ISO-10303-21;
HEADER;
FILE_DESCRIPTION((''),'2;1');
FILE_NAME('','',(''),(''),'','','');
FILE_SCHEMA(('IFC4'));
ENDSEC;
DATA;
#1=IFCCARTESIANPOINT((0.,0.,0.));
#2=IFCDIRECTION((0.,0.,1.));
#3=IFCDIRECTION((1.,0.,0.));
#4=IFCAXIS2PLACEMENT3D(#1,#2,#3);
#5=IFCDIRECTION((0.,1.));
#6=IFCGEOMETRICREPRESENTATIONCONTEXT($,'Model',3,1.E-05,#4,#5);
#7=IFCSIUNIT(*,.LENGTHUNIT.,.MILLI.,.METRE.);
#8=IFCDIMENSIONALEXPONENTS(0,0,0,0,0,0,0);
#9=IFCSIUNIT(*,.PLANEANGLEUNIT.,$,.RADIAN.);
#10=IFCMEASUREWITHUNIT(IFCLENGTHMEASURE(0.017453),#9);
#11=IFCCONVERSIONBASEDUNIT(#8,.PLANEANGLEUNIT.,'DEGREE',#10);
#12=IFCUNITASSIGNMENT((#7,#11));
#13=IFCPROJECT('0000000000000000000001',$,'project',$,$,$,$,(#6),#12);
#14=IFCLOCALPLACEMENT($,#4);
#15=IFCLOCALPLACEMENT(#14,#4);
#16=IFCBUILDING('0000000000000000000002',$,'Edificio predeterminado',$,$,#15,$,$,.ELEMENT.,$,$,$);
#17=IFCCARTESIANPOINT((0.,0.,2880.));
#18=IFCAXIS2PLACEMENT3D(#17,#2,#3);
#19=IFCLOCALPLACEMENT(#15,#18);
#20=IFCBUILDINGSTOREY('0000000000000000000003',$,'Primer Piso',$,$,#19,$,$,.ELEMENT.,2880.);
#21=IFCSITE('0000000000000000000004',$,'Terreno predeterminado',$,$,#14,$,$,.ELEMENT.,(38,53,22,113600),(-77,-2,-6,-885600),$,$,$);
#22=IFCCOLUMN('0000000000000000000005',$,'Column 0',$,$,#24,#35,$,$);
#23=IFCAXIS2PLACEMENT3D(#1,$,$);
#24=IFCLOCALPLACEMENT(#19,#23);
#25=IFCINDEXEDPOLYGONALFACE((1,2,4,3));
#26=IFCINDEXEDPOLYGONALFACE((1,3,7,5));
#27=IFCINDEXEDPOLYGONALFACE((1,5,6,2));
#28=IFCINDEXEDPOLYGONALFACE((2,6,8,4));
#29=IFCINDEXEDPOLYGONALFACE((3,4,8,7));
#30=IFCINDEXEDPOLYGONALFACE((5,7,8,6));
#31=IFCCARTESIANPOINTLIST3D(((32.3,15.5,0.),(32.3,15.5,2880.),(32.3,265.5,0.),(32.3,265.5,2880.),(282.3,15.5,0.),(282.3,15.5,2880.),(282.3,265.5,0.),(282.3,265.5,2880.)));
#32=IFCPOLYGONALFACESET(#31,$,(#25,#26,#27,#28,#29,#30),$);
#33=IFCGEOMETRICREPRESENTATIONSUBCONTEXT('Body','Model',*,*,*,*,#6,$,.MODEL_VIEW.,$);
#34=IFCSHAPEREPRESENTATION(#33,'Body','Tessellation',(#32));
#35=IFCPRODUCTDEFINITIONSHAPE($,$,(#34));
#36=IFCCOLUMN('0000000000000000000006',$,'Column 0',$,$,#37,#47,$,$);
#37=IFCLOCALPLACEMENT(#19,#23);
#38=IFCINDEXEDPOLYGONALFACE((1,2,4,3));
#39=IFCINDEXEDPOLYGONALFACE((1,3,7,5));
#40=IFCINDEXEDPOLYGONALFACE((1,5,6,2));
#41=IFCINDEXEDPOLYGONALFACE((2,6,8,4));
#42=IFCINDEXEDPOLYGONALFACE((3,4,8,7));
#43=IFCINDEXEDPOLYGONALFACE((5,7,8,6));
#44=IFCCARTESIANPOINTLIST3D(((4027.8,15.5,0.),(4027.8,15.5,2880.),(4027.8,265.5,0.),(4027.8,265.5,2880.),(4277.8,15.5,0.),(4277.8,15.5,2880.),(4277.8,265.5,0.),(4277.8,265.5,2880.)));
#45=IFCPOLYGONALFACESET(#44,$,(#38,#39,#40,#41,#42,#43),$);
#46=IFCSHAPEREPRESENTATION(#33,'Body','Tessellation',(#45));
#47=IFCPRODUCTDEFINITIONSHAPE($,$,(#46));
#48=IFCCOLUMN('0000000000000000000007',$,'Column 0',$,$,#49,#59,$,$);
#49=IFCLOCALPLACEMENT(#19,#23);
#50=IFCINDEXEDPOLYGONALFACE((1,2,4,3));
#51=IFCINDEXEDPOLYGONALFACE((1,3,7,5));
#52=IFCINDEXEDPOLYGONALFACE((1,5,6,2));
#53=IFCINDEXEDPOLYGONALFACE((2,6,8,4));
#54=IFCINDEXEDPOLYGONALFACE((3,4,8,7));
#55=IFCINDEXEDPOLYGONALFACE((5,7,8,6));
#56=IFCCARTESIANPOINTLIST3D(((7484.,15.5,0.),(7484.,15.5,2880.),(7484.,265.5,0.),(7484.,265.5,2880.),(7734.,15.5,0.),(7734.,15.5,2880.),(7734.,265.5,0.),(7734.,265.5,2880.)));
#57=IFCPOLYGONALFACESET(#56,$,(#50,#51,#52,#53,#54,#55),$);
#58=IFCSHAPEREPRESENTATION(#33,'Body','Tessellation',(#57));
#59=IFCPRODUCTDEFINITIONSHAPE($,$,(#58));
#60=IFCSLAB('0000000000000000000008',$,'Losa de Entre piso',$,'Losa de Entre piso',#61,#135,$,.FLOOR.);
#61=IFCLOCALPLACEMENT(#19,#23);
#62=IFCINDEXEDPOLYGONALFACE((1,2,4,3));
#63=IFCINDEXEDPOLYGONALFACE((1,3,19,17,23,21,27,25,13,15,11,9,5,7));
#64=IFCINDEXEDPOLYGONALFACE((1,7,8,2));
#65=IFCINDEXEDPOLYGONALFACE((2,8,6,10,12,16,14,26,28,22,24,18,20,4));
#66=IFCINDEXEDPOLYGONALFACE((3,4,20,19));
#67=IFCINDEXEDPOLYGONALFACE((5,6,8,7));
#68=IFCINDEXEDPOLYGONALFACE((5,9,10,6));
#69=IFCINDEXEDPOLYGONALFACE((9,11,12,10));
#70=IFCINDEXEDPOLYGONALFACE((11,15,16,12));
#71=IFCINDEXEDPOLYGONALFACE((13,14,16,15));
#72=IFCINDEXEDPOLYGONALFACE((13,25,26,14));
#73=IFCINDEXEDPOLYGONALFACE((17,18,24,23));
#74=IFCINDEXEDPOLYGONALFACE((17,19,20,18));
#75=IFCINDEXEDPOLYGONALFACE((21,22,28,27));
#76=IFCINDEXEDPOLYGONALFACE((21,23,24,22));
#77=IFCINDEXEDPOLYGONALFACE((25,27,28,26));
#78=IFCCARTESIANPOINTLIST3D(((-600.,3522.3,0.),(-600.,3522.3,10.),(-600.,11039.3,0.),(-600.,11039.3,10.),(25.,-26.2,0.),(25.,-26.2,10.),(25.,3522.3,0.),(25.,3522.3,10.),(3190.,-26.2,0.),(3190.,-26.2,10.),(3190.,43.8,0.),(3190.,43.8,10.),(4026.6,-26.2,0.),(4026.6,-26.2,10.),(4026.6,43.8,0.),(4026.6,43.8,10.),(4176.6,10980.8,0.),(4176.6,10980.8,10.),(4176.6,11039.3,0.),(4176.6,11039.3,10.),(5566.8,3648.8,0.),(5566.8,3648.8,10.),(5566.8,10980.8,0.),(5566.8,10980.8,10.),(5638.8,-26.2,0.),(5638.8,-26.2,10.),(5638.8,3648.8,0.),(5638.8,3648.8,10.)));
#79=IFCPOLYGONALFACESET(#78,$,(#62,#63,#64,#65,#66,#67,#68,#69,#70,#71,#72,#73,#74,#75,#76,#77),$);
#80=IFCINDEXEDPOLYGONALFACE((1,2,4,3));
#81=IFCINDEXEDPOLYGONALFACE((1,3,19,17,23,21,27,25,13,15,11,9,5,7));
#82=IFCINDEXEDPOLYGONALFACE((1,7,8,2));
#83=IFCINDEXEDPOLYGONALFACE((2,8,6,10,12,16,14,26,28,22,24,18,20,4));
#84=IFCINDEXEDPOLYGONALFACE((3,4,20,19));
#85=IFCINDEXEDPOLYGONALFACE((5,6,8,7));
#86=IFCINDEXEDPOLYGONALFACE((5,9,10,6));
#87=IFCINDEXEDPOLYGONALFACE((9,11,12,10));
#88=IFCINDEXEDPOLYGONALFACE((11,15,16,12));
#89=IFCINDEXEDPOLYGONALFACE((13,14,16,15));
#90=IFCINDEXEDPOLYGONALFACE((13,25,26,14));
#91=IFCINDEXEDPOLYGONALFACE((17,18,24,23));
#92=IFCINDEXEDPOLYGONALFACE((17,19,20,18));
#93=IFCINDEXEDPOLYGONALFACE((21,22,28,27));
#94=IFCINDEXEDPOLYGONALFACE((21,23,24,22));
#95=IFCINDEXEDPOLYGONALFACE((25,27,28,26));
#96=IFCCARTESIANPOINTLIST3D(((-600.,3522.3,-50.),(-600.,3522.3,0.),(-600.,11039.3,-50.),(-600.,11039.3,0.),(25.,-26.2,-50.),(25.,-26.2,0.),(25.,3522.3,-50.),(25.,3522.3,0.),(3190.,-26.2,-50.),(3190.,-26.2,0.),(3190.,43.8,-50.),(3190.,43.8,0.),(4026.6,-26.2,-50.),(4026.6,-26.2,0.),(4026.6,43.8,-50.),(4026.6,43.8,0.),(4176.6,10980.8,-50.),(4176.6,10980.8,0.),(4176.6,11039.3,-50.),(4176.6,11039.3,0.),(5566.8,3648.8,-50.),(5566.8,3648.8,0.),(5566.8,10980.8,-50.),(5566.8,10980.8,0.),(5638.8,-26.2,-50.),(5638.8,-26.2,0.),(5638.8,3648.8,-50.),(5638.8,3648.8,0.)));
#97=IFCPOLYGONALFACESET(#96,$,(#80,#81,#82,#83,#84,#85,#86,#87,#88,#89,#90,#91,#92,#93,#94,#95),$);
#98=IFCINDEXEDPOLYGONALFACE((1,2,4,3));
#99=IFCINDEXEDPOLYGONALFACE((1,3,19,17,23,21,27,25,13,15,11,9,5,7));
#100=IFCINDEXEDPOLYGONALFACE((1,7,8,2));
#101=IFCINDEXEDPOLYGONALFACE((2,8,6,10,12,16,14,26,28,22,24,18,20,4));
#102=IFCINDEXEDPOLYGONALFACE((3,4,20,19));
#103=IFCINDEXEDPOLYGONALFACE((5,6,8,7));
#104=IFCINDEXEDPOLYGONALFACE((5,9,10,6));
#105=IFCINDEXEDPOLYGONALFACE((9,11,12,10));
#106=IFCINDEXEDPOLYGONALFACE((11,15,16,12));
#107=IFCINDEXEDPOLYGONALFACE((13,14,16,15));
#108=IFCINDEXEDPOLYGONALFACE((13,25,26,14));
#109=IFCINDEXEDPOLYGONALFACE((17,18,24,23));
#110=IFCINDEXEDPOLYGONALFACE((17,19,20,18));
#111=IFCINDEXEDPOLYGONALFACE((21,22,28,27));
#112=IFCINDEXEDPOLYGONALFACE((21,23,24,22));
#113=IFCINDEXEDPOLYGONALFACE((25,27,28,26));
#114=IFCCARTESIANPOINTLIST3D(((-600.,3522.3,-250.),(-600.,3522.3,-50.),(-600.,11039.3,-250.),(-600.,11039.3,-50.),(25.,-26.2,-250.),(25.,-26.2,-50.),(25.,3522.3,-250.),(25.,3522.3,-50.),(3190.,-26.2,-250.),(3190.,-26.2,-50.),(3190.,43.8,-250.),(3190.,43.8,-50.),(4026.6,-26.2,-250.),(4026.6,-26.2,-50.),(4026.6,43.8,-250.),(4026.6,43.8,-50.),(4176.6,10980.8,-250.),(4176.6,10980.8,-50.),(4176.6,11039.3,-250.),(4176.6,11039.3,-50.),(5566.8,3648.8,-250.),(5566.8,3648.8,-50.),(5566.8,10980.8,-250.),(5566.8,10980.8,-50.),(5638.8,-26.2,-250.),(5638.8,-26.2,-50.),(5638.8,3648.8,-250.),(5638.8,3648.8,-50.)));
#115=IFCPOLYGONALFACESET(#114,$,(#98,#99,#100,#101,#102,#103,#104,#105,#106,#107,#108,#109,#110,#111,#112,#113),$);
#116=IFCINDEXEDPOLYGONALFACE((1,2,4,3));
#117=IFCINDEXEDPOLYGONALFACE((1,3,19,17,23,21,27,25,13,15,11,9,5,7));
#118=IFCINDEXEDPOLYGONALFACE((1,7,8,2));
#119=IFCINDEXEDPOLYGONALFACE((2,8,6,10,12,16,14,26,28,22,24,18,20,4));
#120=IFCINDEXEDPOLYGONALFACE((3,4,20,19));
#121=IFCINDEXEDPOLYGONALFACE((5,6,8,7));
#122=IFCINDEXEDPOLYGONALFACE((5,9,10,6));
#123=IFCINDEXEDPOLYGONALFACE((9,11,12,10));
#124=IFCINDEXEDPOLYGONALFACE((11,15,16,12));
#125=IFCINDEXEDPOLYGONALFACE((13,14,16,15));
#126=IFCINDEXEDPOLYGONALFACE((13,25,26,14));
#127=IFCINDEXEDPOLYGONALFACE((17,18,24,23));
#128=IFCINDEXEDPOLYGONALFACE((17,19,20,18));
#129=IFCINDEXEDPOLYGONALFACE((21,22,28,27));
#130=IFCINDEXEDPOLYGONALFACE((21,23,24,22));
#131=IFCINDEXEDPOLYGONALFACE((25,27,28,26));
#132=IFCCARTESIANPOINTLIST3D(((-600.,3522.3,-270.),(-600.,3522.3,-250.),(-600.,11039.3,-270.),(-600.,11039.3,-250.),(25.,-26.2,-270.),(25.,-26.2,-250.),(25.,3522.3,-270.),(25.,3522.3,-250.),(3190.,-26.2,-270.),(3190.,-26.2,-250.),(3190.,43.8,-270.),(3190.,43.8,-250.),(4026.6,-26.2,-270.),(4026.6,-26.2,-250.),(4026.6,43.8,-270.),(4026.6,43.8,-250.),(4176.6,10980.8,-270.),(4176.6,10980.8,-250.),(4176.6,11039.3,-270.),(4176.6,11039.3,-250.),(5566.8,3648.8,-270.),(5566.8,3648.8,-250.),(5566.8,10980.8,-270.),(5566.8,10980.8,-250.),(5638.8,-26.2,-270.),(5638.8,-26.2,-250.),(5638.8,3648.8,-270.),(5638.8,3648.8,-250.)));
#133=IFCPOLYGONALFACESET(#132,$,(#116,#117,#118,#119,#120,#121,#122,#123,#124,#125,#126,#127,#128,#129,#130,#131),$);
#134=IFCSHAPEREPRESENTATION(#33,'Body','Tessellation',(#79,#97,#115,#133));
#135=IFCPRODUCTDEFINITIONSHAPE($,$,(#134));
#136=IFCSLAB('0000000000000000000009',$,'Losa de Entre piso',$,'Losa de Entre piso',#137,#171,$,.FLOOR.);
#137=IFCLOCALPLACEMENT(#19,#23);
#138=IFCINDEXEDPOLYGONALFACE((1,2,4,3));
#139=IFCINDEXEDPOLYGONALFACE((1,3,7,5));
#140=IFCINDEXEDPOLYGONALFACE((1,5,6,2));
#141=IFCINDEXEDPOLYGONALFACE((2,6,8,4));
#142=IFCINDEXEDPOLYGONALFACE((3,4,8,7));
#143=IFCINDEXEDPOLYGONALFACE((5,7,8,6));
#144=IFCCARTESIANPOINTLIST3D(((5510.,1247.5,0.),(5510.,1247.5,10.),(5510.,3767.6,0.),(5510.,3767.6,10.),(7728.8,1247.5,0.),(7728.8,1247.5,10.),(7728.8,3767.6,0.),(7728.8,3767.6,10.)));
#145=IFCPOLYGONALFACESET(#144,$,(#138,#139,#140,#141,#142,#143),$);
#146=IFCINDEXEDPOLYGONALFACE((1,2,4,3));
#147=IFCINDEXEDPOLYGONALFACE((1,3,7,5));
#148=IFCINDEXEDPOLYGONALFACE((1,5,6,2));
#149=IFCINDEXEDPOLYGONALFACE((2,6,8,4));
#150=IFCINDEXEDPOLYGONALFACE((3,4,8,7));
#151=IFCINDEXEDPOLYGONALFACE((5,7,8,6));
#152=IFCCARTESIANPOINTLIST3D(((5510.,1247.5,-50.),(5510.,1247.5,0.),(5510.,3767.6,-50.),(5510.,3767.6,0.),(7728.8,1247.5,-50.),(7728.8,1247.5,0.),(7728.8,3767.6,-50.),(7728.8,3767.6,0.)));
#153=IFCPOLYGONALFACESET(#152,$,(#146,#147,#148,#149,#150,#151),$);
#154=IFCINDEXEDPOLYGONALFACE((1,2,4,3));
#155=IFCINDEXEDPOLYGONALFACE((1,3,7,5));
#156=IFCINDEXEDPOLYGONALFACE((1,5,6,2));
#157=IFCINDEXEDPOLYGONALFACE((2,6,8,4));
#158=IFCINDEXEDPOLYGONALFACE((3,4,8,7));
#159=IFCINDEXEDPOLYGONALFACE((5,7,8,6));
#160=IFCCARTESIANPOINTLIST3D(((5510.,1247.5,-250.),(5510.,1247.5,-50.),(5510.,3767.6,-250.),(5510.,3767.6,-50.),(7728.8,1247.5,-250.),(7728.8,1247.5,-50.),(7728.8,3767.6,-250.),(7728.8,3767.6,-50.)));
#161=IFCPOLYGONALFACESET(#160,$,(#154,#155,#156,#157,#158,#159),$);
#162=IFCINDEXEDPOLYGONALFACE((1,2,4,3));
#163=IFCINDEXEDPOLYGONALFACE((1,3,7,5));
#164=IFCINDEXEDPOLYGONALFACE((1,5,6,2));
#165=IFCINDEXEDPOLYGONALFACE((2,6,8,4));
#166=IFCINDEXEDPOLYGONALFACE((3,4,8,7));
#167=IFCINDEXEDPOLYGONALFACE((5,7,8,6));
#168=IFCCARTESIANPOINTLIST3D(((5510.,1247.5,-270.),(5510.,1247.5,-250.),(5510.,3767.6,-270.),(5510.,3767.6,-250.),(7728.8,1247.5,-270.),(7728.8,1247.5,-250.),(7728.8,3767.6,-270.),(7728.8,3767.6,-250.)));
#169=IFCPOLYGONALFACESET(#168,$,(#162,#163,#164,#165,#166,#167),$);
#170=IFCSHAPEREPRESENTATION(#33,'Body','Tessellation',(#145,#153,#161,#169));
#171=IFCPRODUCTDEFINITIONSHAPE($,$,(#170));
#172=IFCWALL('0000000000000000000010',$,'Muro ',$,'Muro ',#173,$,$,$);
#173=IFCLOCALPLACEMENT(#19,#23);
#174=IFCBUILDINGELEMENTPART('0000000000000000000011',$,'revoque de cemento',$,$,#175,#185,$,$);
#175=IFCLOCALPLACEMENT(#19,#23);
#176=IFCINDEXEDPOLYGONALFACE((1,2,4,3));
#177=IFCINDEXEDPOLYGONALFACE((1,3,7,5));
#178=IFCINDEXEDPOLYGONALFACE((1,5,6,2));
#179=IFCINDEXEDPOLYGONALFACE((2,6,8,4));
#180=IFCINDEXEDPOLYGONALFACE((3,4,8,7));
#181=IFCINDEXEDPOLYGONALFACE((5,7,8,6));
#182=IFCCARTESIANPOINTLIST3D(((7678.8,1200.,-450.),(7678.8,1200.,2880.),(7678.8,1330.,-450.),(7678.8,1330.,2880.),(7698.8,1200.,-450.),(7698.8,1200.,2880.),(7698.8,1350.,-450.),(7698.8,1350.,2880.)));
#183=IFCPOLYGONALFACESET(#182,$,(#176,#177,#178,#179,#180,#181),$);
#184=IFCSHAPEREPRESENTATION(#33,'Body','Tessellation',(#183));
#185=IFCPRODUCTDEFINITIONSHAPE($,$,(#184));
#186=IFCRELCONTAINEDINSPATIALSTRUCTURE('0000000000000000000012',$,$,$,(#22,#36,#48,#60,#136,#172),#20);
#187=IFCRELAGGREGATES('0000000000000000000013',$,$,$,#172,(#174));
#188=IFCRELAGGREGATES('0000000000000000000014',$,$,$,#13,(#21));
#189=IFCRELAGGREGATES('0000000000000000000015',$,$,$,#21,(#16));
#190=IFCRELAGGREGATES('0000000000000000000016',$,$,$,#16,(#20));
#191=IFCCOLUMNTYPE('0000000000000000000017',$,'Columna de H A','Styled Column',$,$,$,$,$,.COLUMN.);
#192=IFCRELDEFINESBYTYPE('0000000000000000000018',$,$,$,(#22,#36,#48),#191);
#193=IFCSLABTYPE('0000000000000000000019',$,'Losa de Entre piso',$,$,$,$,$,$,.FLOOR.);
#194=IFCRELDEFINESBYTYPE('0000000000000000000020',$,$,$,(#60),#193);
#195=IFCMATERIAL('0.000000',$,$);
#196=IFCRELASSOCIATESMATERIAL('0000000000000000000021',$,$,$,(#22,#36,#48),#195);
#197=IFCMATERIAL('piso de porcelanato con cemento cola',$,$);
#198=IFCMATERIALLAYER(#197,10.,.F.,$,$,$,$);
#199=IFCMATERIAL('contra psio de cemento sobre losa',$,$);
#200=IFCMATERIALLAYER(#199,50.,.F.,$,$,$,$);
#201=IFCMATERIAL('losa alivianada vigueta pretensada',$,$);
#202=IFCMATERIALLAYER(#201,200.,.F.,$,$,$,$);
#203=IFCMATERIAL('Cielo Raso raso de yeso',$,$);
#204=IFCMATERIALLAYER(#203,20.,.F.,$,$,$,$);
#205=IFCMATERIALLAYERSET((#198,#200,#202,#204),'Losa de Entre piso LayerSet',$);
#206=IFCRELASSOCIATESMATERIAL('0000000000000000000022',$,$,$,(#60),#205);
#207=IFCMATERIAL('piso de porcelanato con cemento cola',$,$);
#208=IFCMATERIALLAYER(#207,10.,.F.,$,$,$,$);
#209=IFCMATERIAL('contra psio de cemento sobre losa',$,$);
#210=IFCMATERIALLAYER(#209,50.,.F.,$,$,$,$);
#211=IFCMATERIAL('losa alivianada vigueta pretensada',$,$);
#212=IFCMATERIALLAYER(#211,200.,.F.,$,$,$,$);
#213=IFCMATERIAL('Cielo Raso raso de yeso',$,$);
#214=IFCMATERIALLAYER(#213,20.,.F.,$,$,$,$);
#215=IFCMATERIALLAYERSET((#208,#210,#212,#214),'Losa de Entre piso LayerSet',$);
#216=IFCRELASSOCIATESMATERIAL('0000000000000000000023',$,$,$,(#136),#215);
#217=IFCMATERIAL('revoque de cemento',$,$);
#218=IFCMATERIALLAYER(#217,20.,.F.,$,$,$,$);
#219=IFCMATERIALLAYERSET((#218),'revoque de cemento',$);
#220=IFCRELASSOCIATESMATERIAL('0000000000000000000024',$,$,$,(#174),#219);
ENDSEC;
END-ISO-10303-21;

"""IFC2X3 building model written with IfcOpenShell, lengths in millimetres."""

from ifc_helpers import new_model, entity, si_unit, converted_unit, direction, frame, origin_with_axes, place, context, subcontext, project, spatial, polyline, outline, extrude, clip, bounded_halfspace, material, layer, layer_set, layer_usage, type_object, element, aggregate, save


model = new_model("IFC2X3")

# Units and contexts
model_context = context("Model", 3, precision=1e-05, world=origin_with_axes(), true_north=direction((0.0, 1.0)))
body_context = subcontext(model_context, "Body", "Model", "MODEL_VIEW")
ifc_project = project(units=[si_unit("LENGTHUNIT", "METRE", prefix="MILLI"), converted_unit("PLANEANGLEUNIT", "DEGREE", entity("IfcLengthMeasure", 0.017453), si_unit("PLANEANGLEUNIT", "RADIAN"), dimensions=[0, 0, 0, 0, 0, 0, 0])], contexts=[model_context])

# Site, building, storey
site_placement = place(None, origin_with_axes())
site = spatial("IfcSite", under=ifc_project, at=site_placement, Name="Terreno predeterminado", CompositionType="ELEMENT", RefLatitude=(38, 53, 22, 113600), RefLongitude=(-77, -2, -6, -885600))
building_placement = place(site_placement, origin_with_axes())
building = spatial("IfcBuilding", under=site, at=building_placement, Name="Edificio predeterminado", CompositionType="ELEMENT")
storey_placement = place(building_placement, frame((0.0, 0.0, 2880.0), z_axis=(0.0, 0.0, 1.0), x_axis=(1.0, 0.0, 0.0)))
storey = spatial("IfcBuildingStorey", under=building, at=storey_placement, Name="Primer Piso", CompositionType="ELEMENT", Elevation=2880.0)

# Columns
ifc_material_1 = material(Name="0.000000")
column_type = type_object("IfcColumnType", Name="Columna de H A", Description="Styled Column", PredefinedType="COLUMN")
for number, where, z_axis, x_axis, name in (
    (1, (157.3, 140.5, 0.0), (0.0, 0.0, 1.0), (1.0, 0.0, 0.0), "Column 0"),
    (2, (4152.8, 140.5, 0.0), (0.0, 0.0, 1.0), (1.0, 0.0, 0.0), "Column 0"),
    (3, (7609.0, 140.5, 0.0), (0.0, 0.0, 1.0), (1.0, 0.0, 0.0), "Column 0"),
):
    element("IfcColumn", number, at=place(storey_placement, frame(where, z_axis=z_axis, x_axis=x_axis)), inside=storey, type_object=column_type, material=ifc_material_1, Name=name, context=body_context, shape_type="SweptSolid", body=[
        extrude(outline(polyline([(-125.0, -125.0), (125.0, -125.0), (125.0, 125.0), (-125.0, 125.0), (-125.0, -125.0)])), origin_with_axes(), (0.0, 0.0, 1.0), 2880.0),
    ])

# Slabs
ifc_material_2 = material(Name="piso de porcelanato con cemento cola")
ifc_layer_1 = layer(ifc_material_2, 10.0, ventilated=False)
ifc_material_3 = material(Name="contra psio de cemento sobre losa")
ifc_layer_2 = layer(ifc_material_3, 50.0, ventilated=False)
ifc_material_4 = material(Name="losa alivianada vigueta pretensada")
ifc_layer_3 = layer(ifc_material_4, 200.0, ventilated=False)
ifc_material_5 = material(Name="Cielo Raso raso de yeso")
ifc_layer_4 = layer(ifc_material_5, 20.0, ventilated=False)
ifc_layer_set_1 = layer_set([ifc_layer_1, ifc_layer_2, ifc_layer_3, ifc_layer_4], Name="Losa de Entre piso LayerSet")
ifc_layer_usage_1 = layer_usage(ifc_layer_set_1, "AXIS3", "POSITIVE", 0.0)
slab_type = type_object("IfcSlabType", Name="Losa de Entre piso", PredefinedType="FLOOR")
slab_1_placement = place(storey_placement, frame((0.0, 0.0, -2880.0), z_axis=(0.0, 0.0, 1.0), x_axis=(1.0, 0.0, 0.0)))
element("IfcSlab", 4, at=slab_1_placement, inside=storey, type_object=slab_type, material=ifc_layer_usage_1, Name="Losa de Entre piso", ObjectType="Losa de Entre piso", PredefinedType="FLOOR", context=body_context, shape_type="SweptSolid", body=[
    extrude(outline(polyline([(0.0, -1390.2), (-58.5, -1390.2), (-58.5, -6166.8), (7458.5, -6166.8), (7458.5, -5541.8), (11007.0, -5541.8), (11007.0, -2376.8), (10937.0, -2376.8), (10937.0, -1540.2), (11007.0, -1540.2), (11007.0, 72.1), (7332.0, 72.1), (7332.0, 0.0), (0.0, 0.0), (0.0, -1390.2)])), frame((5566.8, 10980.8, 2880.0), z_axis=(0.0, 0.0, 1.0), x_axis=(0.0, -1.0, 0.0)), (0.0, 0.0, 1.0), 10.0),
    extrude(outline(polyline([(0.0, -1390.2), (-58.5, -1390.2), (-58.5, -6166.8), (7458.5, -6166.8), (7458.5, -5541.8), (11007.0, -5541.8), (11007.0, -2376.8), (10937.0, -2376.8), (10937.0, -1540.2), (11007.0, -1540.2), (11007.0, 72.1), (7332.0, 72.1), (7332.0, 0.0), (0.0, 0.0), (0.0, -1390.2)])), frame((5566.8, 10980.8, 2830.0), z_axis=(0.0, 0.0, 1.0), x_axis=(0.0, -1.0, 0.0)), (0.0, 0.0, 1.0), 50.0),
    extrude(outline(polyline([(0.0, -1390.2), (-58.5, -1390.2), (-58.5, -6166.8), (7458.5, -6166.8), (7458.5, -5541.8), (11007.0, -5541.8), (11007.0, -2376.8), (10937.0, -2376.8), (10937.0, -1540.2), (11007.0, -1540.2), (11007.0, 72.1), (7332.0, 72.1), (7332.0, 0.0), (0.0, 0.0), (0.0, -1390.2)])), frame((5566.8, 10980.8, 2630.0), z_axis=(0.0, 0.0, 1.0), x_axis=(0.0, -1.0, 0.0)), (0.0, 0.0, 1.0), 200.0),
    extrude(outline(polyline([(0.0, -1390.2), (-58.5, -1390.2), (-58.5, -6166.8), (7458.5, -6166.8), (7458.5, -5541.8), (11007.0, -5541.8), (11007.0, -2376.8), (10937.0, -2376.8), (10937.0, -1540.2), (11007.0, -1540.2), (11007.0, 72.1), (7332.0, 72.1), (7332.0, 0.0), (0.0, 0.0), (0.0, -1390.2)])), frame((5566.8, 10980.8, 2610.0), z_axis=(0.0, 0.0, 1.0), x_axis=(0.0, -1.0, 0.0)), (0.0, 0.0, 1.0), 20.0),
])
ifc_material_6 = material(Name="piso de porcelanato con cemento cola")
ifc_layer_5 = layer(ifc_material_6, 10.0, ventilated=False)
ifc_material_7 = material(Name="contra psio de cemento sobre losa")
ifc_layer_6 = layer(ifc_material_7, 50.0, ventilated=False)
ifc_material_8 = material(Name="losa alivianada vigueta pretensada")
ifc_layer_7 = layer(ifc_material_8, 200.0, ventilated=False)
ifc_material_9 = material(Name="Cielo Raso raso de yeso")
ifc_layer_8 = layer(ifc_material_9, 20.0, ventilated=False)
ifc_layer_set_2 = layer_set([ifc_layer_5, ifc_layer_6, ifc_layer_7, ifc_layer_8], Name="Losa de Entre piso LayerSet")
ifc_layer_usage_2 = layer_usage(ifc_layer_set_2, "AXIS3", "POSITIVE", 0.0)
slab_2_placement = place(storey_placement, frame((0.0, 0.0, -2880.0), z_axis=(0.0, 0.0, 1.0), x_axis=(1.0, 0.0, 0.0)))
element("IfcSlab", 5, at=slab_2_placement, inside=storey, material=ifc_layer_usage_2, Name="Losa de Entre piso", ObjectType="Losa de Entre piso", PredefinedType="FLOOR", context=body_context, shape_type="SweptSolid", body=[
    extrude(outline(polyline([(0.0, 0.0), (2218.8, 0.0), (2218.8, 2520.2), (0.0, 2520.2), (0.0, 0.0)])), frame((7728.8, 1247.5, 2880.0), z_axis=(0.0, 0.0, -1.0), x_axis=(-1.0, 0.0, 0.0)), (0.0, 0.0, -1.0), 10.0),
    extrude(outline(polyline([(0.0, 0.0), (2218.8, 0.0), (2218.8, 2520.2), (0.0, 2520.2), (0.0, 0.0)])), frame((7728.8, 1247.5, 2830.0), z_axis=(0.0, 0.0, -1.0), x_axis=(-1.0, 0.0, 0.0)), (0.0, 0.0, -1.0), 50.0),
    extrude(outline(polyline([(0.0, 0.0), (2218.8, 0.0), (2218.8, 2520.2), (0.0, 2520.2), (0.0, 0.0)])), frame((7728.8, 1247.5, 2630.0), z_axis=(0.0, 0.0, -1.0), x_axis=(-1.0, 0.0, 0.0)), (0.0, 0.0, -1.0), 200.0),
    extrude(outline(polyline([(0.0, 0.0), (2218.8, 0.0), (2218.8, 2520.2), (0.0, 2520.2), (0.0, 0.0)])), frame((7728.8, 1247.5, 2610.0), z_axis=(0.0, 0.0, -1.0), x_axis=(-1.0, 0.0, 0.0)), (0.0, 0.0, -1.0), 20.0),
])

# Wall, building element part
wall_1_placement = place(storey_placement, frame((7623.8, 1275.0, 0.0), z_axis=(0.0, 0.0, 1.0), x_axis=(0.0, -1.0, 0.0)))
wall_1 = element("IfcWall", 6, at=wall_1_placement, inside=storey, Name="Muro ", ObjectType="Muro ")
ifc_material_10 = material(Name="revoque de cemento")
ifc_layer_9 = layer(ifc_material_10, 20.0, ventilated=False)
ifc_layer_set_3 = layer_set([ifc_layer_9], Name="revoque de cemento")
ifc_layer_usage_3 = layer_usage(ifc_layer_set_3, "AXIS2", "NEGATIVE", -75.0)
building_element_part_1_placement = place(wall_1_placement, origin_with_axes())
building_element_part_1 = element("IfcBuildingElementPart", 7, at=building_element_part_1_placement, material=ifc_layer_usage_3, Name="revoque de cemento", context=body_context, shape_type="Clipping", body=[
    clip(clip(extrude(outline(polyline([(75.0, 75.0), (75.0, 55.0), (-55.0, 55.0), (-75.0, 75.0), (75.0, 75.0)])), frame((0.0, 0.0, -450.0), z_axis=(0.0, 0.0, 1.0), x_axis=(1.0, 0.0, 0.0)), (0.0, 0.0, 1.0), 3330.0), bounded_halfspace(frame((0.0, 0.0, -450.0), z_axis=(0.0, 0.0, 1.0), x_axis=(1.0, 0.0, 0.0)), True, origin_with_axes(), polyline([(-150.0, -150.0), (225.0, -150.0), (225.0, 150.0), (-150.0, 150.0), (-150.0, -150.0)]))), bounded_halfspace(frame((0.0, 0.0, 2880.0), z_axis=(0.0, 0.0, 1.0), x_axis=(1.0, 0.0, 0.0)), False, origin_with_axes(), polyline([(-150.0, -150.0), (225.0, -150.0), (225.0, 150.0), (-150.0, 150.0), (-150.0, -150.0)]))),
])
aggregate(wall_1, [building_element_part_1])

save(model, "model.ifc")
